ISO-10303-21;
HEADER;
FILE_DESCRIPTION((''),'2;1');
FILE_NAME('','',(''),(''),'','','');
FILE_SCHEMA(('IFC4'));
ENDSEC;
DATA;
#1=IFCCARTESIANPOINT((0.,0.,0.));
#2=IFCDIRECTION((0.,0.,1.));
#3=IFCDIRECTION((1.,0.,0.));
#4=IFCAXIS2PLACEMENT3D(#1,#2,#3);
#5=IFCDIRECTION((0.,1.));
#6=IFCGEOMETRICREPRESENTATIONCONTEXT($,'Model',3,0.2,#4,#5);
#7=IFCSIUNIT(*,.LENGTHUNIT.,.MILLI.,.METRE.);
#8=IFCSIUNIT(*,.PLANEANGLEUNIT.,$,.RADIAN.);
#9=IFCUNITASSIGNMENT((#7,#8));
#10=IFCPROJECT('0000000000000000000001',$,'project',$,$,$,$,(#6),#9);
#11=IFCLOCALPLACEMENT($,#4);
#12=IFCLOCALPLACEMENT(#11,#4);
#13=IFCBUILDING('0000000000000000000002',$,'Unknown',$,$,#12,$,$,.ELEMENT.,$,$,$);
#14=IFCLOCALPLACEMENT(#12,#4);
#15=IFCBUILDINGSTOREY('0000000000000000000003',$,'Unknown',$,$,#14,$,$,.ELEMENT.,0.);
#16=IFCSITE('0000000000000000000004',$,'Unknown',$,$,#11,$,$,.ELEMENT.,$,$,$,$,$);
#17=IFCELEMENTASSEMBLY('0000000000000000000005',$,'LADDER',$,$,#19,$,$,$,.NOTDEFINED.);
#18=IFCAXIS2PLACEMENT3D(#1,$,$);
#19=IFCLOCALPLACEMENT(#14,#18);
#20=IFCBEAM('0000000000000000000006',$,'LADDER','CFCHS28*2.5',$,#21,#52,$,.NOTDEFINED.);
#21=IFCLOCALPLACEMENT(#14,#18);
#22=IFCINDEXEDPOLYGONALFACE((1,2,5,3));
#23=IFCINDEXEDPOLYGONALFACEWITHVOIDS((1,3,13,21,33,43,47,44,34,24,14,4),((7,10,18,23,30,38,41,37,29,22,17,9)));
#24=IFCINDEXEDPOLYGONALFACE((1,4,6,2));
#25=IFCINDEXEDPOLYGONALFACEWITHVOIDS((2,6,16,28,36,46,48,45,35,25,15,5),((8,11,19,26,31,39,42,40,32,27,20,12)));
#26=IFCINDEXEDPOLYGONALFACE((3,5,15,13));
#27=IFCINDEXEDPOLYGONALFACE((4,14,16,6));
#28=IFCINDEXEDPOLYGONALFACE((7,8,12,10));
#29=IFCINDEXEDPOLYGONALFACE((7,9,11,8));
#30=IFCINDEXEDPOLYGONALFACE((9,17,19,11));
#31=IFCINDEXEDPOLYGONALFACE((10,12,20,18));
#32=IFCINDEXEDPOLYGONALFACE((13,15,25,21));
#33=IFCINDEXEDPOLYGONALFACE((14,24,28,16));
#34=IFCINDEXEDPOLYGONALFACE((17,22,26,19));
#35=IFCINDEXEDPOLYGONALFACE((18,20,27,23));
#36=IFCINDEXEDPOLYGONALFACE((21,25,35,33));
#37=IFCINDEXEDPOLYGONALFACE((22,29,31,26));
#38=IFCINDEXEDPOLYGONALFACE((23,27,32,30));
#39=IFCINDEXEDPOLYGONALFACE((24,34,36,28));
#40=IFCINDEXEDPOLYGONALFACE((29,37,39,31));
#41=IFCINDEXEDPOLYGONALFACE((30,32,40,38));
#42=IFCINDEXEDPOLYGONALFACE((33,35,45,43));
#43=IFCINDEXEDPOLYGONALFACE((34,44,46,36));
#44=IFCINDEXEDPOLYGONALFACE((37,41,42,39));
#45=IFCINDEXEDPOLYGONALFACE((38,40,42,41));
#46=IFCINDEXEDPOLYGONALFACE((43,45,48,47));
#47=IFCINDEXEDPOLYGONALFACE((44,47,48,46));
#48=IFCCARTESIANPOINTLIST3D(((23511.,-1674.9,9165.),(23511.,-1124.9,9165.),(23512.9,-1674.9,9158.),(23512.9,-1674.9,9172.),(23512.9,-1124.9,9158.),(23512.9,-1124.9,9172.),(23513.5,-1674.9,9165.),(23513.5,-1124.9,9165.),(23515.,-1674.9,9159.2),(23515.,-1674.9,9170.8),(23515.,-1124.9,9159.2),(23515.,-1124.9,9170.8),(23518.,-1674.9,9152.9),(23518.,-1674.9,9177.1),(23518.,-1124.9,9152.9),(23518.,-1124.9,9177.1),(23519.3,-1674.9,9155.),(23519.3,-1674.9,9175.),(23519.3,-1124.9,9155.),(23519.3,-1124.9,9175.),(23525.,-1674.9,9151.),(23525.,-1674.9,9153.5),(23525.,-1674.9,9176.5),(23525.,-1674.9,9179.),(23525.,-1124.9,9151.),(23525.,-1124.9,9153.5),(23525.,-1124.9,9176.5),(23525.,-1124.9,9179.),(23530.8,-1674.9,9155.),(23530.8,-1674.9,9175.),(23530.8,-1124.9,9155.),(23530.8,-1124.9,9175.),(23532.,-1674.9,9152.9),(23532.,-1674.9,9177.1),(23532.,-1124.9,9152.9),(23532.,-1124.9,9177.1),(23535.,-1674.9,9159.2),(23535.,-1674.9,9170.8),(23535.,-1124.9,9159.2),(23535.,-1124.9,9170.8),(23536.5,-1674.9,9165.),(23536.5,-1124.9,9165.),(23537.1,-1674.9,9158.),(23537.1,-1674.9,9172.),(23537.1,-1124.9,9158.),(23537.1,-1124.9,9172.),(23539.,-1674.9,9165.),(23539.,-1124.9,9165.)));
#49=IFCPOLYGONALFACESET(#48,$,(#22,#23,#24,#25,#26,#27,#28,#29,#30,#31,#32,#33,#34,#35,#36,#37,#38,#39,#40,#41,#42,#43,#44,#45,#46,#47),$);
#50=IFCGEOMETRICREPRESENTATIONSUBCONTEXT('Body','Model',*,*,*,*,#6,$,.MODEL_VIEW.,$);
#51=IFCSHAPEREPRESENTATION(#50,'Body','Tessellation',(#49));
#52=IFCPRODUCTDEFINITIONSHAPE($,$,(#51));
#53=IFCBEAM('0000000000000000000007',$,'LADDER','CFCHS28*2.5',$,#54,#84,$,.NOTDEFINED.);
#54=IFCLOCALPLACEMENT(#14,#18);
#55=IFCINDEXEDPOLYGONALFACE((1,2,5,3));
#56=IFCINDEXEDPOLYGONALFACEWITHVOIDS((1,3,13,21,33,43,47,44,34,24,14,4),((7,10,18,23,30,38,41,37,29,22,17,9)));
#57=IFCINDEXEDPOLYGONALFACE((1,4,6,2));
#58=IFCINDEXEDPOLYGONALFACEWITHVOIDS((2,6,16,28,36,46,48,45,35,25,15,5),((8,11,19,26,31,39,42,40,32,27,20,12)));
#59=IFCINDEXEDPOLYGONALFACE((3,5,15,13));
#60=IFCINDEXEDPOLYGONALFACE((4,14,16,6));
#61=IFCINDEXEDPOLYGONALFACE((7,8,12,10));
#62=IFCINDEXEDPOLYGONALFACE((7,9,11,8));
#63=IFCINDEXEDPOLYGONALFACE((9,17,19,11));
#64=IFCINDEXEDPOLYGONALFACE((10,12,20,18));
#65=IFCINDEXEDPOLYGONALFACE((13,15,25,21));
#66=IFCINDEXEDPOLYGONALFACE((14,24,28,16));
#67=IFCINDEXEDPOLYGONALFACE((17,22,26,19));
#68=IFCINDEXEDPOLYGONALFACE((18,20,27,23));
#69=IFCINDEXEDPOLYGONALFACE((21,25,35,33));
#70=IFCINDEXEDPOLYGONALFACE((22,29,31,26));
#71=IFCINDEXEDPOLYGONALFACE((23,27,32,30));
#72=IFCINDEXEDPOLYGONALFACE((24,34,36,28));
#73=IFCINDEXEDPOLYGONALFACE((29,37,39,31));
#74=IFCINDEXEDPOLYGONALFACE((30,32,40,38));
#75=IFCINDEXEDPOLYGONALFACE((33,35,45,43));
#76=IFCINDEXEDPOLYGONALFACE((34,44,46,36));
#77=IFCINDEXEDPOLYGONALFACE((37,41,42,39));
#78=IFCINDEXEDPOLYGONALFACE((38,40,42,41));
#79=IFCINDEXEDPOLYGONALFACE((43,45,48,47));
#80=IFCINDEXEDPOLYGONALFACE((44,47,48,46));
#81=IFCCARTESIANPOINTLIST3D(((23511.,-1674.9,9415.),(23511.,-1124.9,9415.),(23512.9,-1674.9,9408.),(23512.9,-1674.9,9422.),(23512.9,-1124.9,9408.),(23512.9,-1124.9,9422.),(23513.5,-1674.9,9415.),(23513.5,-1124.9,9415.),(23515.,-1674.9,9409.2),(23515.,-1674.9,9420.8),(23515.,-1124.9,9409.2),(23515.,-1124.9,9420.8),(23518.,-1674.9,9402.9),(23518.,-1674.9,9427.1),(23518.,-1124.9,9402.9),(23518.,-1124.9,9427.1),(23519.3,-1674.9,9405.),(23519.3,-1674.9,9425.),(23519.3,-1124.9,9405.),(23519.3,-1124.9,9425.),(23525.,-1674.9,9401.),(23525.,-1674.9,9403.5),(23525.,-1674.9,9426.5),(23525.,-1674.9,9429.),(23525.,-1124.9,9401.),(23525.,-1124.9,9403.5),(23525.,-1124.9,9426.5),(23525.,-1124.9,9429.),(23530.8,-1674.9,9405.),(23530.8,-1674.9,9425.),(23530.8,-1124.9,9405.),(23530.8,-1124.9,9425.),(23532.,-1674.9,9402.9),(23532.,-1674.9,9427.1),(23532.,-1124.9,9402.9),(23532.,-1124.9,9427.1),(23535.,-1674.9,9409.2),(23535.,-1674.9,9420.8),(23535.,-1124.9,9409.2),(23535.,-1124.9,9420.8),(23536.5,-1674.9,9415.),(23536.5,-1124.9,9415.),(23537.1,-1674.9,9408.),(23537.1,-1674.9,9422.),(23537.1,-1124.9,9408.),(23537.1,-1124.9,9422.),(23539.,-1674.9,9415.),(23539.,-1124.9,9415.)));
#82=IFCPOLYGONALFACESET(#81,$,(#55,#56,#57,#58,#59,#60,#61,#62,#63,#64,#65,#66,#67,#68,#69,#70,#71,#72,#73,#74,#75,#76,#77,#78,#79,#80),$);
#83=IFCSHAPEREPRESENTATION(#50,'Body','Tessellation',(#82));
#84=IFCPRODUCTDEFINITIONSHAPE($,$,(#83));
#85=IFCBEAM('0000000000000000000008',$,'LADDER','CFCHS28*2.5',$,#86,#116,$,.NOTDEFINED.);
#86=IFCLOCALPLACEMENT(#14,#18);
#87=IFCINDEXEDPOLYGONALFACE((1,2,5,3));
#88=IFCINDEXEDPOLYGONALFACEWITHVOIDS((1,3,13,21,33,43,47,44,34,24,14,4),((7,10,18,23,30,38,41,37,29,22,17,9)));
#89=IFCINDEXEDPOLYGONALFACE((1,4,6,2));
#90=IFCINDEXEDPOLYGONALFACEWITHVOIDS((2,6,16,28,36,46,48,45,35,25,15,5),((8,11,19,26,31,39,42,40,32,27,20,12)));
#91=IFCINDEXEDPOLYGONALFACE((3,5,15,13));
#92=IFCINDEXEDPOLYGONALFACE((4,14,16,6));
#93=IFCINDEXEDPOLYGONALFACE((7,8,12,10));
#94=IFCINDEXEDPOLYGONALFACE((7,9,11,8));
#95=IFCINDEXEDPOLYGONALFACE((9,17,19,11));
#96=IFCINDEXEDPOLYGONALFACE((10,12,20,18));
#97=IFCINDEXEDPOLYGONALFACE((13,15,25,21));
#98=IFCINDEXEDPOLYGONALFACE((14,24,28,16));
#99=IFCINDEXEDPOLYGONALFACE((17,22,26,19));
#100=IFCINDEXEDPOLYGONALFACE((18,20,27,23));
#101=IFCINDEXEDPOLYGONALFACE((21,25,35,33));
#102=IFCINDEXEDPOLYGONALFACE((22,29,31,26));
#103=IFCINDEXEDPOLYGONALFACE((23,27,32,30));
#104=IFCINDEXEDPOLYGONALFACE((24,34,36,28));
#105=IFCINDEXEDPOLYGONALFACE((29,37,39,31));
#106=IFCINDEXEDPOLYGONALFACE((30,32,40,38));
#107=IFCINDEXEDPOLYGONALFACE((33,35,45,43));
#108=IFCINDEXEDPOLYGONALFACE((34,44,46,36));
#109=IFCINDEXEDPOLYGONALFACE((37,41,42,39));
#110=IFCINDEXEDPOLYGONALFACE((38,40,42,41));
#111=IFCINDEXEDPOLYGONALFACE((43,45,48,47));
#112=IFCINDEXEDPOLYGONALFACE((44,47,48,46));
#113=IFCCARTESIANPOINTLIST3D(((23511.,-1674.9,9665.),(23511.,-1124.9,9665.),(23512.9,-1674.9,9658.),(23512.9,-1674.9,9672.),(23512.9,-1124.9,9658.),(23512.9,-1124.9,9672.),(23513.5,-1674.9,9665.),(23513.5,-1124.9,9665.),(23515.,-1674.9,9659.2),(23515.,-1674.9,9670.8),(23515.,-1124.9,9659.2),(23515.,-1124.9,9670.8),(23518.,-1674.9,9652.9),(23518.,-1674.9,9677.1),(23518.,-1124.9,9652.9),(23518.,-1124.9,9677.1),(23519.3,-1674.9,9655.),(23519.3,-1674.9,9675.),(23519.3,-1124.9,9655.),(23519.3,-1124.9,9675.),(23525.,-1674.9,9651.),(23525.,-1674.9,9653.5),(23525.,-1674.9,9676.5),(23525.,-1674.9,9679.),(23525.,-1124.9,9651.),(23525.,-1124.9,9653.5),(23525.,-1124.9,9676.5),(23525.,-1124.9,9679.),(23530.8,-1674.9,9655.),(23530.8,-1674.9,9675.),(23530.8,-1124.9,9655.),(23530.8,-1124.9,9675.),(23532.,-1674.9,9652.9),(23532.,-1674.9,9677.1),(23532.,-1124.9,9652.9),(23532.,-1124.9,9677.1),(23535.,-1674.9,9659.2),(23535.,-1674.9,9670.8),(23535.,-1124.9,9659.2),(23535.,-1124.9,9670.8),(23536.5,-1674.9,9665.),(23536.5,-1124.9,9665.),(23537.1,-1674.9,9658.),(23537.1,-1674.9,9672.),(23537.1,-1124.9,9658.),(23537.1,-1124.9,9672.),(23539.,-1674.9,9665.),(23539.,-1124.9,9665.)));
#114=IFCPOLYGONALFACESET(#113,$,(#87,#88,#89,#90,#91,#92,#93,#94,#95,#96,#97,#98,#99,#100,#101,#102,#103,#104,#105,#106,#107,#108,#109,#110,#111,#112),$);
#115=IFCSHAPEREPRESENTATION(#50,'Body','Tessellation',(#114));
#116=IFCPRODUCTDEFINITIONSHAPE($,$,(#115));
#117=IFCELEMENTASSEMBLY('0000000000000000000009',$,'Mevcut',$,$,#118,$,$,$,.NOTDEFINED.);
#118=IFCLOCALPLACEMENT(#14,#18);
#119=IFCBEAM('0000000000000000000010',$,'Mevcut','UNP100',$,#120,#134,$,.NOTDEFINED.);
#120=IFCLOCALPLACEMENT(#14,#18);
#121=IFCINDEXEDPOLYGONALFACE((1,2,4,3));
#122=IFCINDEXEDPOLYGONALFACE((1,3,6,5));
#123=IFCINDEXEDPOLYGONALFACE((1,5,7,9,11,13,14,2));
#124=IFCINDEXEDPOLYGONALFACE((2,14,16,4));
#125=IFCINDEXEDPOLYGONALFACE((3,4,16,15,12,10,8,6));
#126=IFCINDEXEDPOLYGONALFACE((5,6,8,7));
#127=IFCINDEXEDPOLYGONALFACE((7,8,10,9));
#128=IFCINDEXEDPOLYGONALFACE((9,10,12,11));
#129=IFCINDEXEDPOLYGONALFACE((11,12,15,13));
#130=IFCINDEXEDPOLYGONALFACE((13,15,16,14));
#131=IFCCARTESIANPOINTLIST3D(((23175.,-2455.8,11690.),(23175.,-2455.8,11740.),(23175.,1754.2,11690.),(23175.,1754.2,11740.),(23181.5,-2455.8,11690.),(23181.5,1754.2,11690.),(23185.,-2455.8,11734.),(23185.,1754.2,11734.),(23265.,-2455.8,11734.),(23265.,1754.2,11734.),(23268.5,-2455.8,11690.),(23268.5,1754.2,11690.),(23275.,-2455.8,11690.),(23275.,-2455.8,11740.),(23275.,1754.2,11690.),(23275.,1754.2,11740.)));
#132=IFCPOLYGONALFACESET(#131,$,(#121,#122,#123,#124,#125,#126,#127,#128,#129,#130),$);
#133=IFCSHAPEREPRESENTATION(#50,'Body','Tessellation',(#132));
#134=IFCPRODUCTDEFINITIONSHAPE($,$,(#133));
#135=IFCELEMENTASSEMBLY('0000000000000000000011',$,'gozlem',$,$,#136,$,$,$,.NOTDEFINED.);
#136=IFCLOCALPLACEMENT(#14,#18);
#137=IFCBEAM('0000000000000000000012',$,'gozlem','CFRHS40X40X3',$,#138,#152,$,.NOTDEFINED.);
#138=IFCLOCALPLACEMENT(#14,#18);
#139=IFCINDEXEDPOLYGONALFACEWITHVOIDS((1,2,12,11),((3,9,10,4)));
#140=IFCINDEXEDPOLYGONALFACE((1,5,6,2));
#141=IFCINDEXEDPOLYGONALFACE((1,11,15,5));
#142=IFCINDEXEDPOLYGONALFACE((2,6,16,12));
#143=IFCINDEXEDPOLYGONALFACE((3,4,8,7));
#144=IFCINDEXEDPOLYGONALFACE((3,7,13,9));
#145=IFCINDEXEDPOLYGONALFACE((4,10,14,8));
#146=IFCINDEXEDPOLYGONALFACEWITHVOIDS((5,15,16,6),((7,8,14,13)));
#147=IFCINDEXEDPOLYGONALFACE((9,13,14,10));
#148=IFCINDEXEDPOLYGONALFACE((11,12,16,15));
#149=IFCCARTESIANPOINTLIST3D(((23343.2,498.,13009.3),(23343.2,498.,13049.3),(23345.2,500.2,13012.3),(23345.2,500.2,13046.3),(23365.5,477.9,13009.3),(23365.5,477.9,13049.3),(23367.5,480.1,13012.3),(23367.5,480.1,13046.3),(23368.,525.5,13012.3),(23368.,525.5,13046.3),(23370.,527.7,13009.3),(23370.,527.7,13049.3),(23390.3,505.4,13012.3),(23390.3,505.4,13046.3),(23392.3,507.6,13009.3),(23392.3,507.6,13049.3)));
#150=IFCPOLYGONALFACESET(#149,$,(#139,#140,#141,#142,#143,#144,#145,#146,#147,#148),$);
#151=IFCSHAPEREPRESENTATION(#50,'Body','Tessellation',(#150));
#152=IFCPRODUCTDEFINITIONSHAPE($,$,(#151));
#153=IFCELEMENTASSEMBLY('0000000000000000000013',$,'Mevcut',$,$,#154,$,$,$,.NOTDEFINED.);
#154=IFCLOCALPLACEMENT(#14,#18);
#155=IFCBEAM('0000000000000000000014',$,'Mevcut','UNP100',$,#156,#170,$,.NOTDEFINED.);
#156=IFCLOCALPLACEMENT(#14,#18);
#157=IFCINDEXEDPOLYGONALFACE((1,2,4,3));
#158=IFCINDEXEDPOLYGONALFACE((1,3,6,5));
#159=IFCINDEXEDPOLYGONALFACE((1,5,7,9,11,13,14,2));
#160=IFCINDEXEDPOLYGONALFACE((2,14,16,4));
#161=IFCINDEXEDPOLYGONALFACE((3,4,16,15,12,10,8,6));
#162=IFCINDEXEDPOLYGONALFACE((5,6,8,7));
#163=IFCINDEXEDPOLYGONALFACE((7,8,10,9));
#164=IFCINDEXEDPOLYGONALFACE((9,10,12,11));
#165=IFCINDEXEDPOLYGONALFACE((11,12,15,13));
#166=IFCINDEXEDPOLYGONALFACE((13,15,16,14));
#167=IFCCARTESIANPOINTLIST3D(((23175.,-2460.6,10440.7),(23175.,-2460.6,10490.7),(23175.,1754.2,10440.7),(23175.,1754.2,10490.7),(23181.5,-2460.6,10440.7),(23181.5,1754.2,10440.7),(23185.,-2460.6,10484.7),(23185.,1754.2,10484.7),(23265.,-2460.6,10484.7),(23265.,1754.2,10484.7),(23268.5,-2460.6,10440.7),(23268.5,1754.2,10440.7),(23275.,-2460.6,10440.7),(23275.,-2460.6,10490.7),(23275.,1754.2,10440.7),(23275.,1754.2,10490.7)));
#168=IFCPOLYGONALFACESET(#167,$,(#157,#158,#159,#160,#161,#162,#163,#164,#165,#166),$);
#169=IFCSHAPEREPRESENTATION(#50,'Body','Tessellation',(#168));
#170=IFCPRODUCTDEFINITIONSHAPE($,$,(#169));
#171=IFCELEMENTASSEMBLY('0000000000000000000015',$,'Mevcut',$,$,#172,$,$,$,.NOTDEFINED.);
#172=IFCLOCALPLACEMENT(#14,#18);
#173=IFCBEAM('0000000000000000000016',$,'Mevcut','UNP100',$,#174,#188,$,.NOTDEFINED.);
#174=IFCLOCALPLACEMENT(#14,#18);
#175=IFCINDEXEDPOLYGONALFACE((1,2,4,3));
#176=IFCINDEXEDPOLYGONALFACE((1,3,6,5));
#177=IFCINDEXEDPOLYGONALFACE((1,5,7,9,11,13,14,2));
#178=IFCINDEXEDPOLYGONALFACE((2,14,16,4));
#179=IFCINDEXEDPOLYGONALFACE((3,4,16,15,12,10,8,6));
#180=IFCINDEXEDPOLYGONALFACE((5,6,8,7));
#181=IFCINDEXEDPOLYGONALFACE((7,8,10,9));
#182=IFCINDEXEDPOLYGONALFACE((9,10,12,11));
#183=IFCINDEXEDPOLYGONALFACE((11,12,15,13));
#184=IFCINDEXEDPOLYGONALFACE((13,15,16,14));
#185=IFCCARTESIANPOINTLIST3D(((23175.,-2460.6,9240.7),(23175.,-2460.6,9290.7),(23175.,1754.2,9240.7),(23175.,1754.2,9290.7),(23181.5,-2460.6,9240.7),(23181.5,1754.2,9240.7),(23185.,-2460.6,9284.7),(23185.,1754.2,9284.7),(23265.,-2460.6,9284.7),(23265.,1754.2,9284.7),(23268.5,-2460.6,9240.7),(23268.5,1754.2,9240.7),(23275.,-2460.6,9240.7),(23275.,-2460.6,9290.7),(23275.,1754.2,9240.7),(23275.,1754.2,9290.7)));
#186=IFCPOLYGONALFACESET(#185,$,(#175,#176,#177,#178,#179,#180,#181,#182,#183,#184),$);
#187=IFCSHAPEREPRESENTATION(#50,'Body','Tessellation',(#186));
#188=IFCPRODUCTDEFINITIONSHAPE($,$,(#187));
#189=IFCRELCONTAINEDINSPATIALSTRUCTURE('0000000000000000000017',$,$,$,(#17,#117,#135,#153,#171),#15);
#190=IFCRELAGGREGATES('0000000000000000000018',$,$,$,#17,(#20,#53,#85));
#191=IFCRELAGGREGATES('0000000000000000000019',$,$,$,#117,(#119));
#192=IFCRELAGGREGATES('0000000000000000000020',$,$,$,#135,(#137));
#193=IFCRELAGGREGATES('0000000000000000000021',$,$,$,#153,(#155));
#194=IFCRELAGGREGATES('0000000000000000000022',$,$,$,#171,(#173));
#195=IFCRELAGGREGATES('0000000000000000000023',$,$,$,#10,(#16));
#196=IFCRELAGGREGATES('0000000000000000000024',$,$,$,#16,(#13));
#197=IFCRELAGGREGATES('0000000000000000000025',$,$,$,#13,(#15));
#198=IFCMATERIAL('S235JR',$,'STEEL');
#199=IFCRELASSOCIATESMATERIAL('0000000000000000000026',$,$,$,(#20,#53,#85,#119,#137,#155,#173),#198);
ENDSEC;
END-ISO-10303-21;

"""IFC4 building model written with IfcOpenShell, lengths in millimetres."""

from ifc_helpers import new_model, si_unit, direction, frame, origin_with_axes, place, context, subcontext, project, spatial, line, indexed_curve, outline, extrude, material, element, aggregate, save


model = new_model("IFC4")

# Units and contexts
model_context = context("Model", 3, precision=0.2, world=origin_with_axes(), true_north=direction((0.0, 1.0)))
body_context = subcontext(model_context, "Body", "Model", "MODEL_VIEW")
ifc_project = project(units=[si_unit("LENGTHUNIT", "METRE", prefix="MILLI"), si_unit("PLANEANGLEUNIT", "RADIAN")], contexts=[model_context])

# Site, building, storey
site_placement = place(None, origin_with_axes())
site = spatial("IfcSite", under=ifc_project, at=site_placement, Name="Unknown", CompositionType="ELEMENT")
building_placement = place(site_placement, origin_with_axes())
building = spatial("IfcBuilding", under=site, at=building_placement, Name="Unknown", CompositionType="ELEMENT")
storey_placement = place(building_placement, origin_with_axes())
storey = spatial("IfcBuildingStorey", under=building, at=storey_placement, Name="Unknown", CompositionType="ELEMENT", Elevation=0.0)

# Element assembly, beams
assembly_1_placement = place(storey_placement, frame((23525.0, -1699.9, 5175.0), z_axis=(0.0, 1.0, 0.0), x_axis=(0.0, 0.0, 1.0)))
assembly_1 = element("IfcElementAssembly", 1, at=assembly_1_placement, inside=storey, Name="LADDER", PredefinedType="NOTDEFINED")
ifc_material = material(Name="S235JR", Category="STEEL")
beam_1_placement = place(assembly_1_placement, frame((3990.0, 0.0, 25.0), z_axis=(0.0, -1.0, 0.0), x_axis=(0.0, 0.0, 1.0)))
beam_1 = element("IfcBeam", 2, at=beam_1_placement, material=ifc_material, Name="LADDER", Description="CFCHS28*2.5", PredefinedType="NOTDEFINED", context=body_context, shape_type="SolidModel", body=[
    extrude(outline(indexed_curve([(14.0, 0.0), (12.1, 7.0), (7.0, 12.1), (0.0, 14.0), (-7.0, 12.1), (-12.1, 7.0), (-14.0, 0.0), (-12.1, -7.0), (-7.0, -12.1), (0.0, -14.0), (7.0, -12.1), (12.1, -7.0)], segments=[line(1, 2, 3, 4, 5, 6, 7, 8, 9, 10, 11, 12, 1)]), holes=[indexed_curve([(11.5, 0.0), (10.0, -5.8), (5.8, -10.0), (0.0, -11.5), (-5.8, -10.0), (-10.0, -5.8), (-11.5, 0.0), (-10.0, 5.8), (-5.8, 10.0), (0.0, 11.5), (5.8, 10.0), (10.0, 5.8)], segments=[line(1, 2, 3, 4, 5, 6, 7, 8, 9, 10, 11, 12, 1)])]), frame((0.0, 0.0, 0.0), z_axis=(-1.0, 0.0, 0.0), x_axis=(0.0, 0.0, 1.0)), (0.0, 0.0, -1.0), 550.0),
])
beam_2_placement = place(assembly_1_placement, frame((4240.0, 0.0, 25.0), z_axis=(0.0, -1.0, 0.0), x_axis=(0.0, 0.0, 1.0)))
beam_2 = element("IfcBeam", 3, at=beam_2_placement, material=ifc_material, Name="LADDER", Description="CFCHS28*2.5", PredefinedType="NOTDEFINED", context=body_context, shape_type="SolidModel", body=[
    extrude(outline(indexed_curve([(14.0, 0.0), (12.1, 7.0), (7.0, 12.1), (0.0, 14.0), (-7.0, 12.1), (-12.1, 7.0), (-14.0, 0.0), (-12.1, -7.0), (-7.0, -12.1), (0.0, -14.0), (7.0, -12.1), (12.1, -7.0)], segments=[line(1, 2, 3, 4, 5, 6, 7, 8, 9, 10, 11, 12, 1)]), holes=[indexed_curve([(11.5, 0.0), (10.0, -5.8), (5.8, -10.0), (0.0, -11.5), (-5.8, -10.0), (-10.0, -5.8), (-11.5, 0.0), (-10.0, 5.8), (-5.8, 10.0), (0.0, 11.5), (5.8, 10.0), (10.0, 5.8)], segments=[line(1, 2, 3, 4, 5, 6, 7, 8, 9, 10, 11, 12, 1)])]), frame((0.0, 0.0, 0.0), z_axis=(-1.0, 0.0, 0.0), x_axis=(0.0, 0.0, 1.0)), (0.0, 0.0, -1.0), 550.0),
])
beam_3_placement = place(assembly_1_placement, frame((4490.0, 0.0, 25.0), z_axis=(0.0, -1.0, 0.0), x_axis=(0.0, 0.0, 1.0)))
beam_3 = element("IfcBeam", 4, at=beam_3_placement, material=ifc_material, Name="LADDER", Description="CFCHS28*2.5", PredefinedType="NOTDEFINED", context=body_context, shape_type="SolidModel", body=[
    extrude(outline(indexed_curve([(14.0, 0.0), (12.1, 7.0), (7.0, 12.1), (0.0, 14.0), (-7.0, 12.1), (-12.1, 7.0), (-14.0, 0.0), (-12.1, -7.0), (-7.0, -12.1), (0.0, -14.0), (7.0, -12.1), (12.1, -7.0)], segments=[line(1, 2, 3, 4, 5, 6, 7, 8, 9, 10, 11, 12, 1)]), holes=[indexed_curve([(11.5, 0.0), (10.0, -5.8), (5.8, -10.0), (0.0, -11.5), (-5.8, -10.0), (-10.0, -5.8), (-11.5, 0.0), (-10.0, 5.8), (-5.8, 10.0), (0.0, 11.5), (5.8, 10.0), (10.0, 5.8)], segments=[line(1, 2, 3, 4, 5, 6, 7, 8, 9, 10, 11, 12, 1)])]), frame((0.0, 0.0, 0.0), z_axis=(-1.0, 0.0, 0.0), x_axis=(0.0, 0.0, 1.0)), (0.0, 0.0, -1.0), 550.0),
])
aggregate(assembly_1, [beam_1, beam_2, beam_3])

# Element assemblies, beams
assembly_2_placement = place(storey_placement, frame((23225.0, 1754.2, 11715.0), z_axis=(0.0, 0.0, -1.0), x_axis=(0.0, -1.0, 0.0)))
assembly_2 = element("IfcElementAssembly", 5, at=assembly_2_placement, inside=storey, Name="Mevcut", PredefinedType="NOTDEFINED")
beam_4_placement = place(assembly_2_placement, origin_with_axes())
beam_4 = element("IfcBeam", 6, at=beam_4_placement, material=ifc_material, Name="Mevcut", Description="UNP100", PredefinedType="NOTDEFINED", context=body_context, shape_type="SolidModel", body=[
    extrude(outline(indexed_curve([(-25.0, -50.0), (25.0, -50.0), (25.0, -43.5), (-19.0, -40.0), (-19.0, 40.0), (25.0, 43.5), (25.0, 50.0), (-25.0, 50.0)], segments=[line(1, 2, 3, 4, 5, 6, 7, 8, 1)])), frame((0.0, 0.0, 0.0), z_axis=(-1.0, 0.0, 0.0), x_axis=(0.0, 0.0, 1.0)), (0.0, 0.0, -1.0), 4210.0),
])
aggregate(assembly_2, [beam_4])
assembly_3_placement = place(storey_placement, frame((23356.6, 512.8, 13029.3), z_axis=(0.0, 0.0, -1.0), x_axis=(0.743145, -0.669131, 0.0)))
assembly_3 = element("IfcElementAssembly", 7, at=assembly_3_placement, inside=storey, Name="gozlem", PredefinedType="NOTDEFINED")
beam_5_placement = place(assembly_3_placement, origin_with_axes())
beam_5 = element("IfcBeam", 8, at=beam_5_placement, material=ifc_material, Name="gozlem", Description="CFRHS40X40X3", PredefinedType="NOTDEFINED", context=body_context, shape_type="SolidModel", body=[
    extrude(outline(indexed_curve([(-20.0, -20.0), (20.0, -20.0), (20.0, 20.0), (-20.0, 20.0)], segments=[line(1, 2, 3, 4, 1)]), holes=[indexed_curve([(-17.0, -17.0), (-17.0, 17.0), (17.0, 17.0), (17.0, -17.0)], segments=[line(1, 2, 3, 4, 1)])]), frame((0.0, 0.0, 0.0), z_axis=(-1.0, 0.0, 0.0), x_axis=(0.0, 0.0, 1.0)), (0.0, 0.0, -1.0), 30.0),
])
aggregate(assembly_3, [beam_5])
assembly_4_placement = place(storey_placement, frame((23225.0, 1754.2, 10465.7), z_axis=(0.0, 0.0, -1.0), x_axis=(0.0, -1.0, 0.0)))
assembly_4 = element("IfcElementAssembly", 9, at=assembly_4_placement, inside=storey, Name="Mevcut", PredefinedType="NOTDEFINED")
beam_6_placement = place(assembly_4_placement, origin_with_axes())
beam_6 = element("IfcBeam", 10, at=beam_6_placement, material=ifc_material, Name="Mevcut", Description="UNP100", PredefinedType="NOTDEFINED", context=body_context, shape_type="SolidModel", body=[
    extrude(outline(indexed_curve([(-25.0, -50.0), (25.0, -50.0), (25.0, -43.5), (-19.0, -40.0), (-19.0, 40.0), (25.0, 43.5), (25.0, 50.0), (-25.0, 50.0)], segments=[line(1, 2, 3, 4, 5, 6, 7, 8, 1)])), frame((0.0, 0.0, 0.0), z_axis=(-1.0, 0.0, 0.0), x_axis=(0.0, 0.0, 1.0)), (0.0, 0.0, -1.0), 4214.9),
])
aggregate(assembly_4, [beam_6])
assembly_5_placement = place(storey_placement, frame((23225.0, 1754.2, 9265.7), z_axis=(0.0, 0.0, -1.0), x_axis=(0.0, -1.0, 0.0)))
assembly_5 = element("IfcElementAssembly", 11, at=assembly_5_placement, inside=storey, Name="Mevcut", PredefinedType="NOTDEFINED")
beam_7_placement = place(assembly_5_placement, origin_with_axes())
beam_7 = element("IfcBeam", 12, at=beam_7_placement, material=ifc_material, Name="Mevcut", Description="UNP100", PredefinedType="NOTDEFINED", context=body_context, shape_type="SolidModel", body=[
    extrude(outline(indexed_curve([(-25.0, -50.0), (25.0, -50.0), (25.0, -43.5), (-19.0, -40.0), (-19.0, 40.0), (25.0, 43.5), (25.0, 50.0), (-25.0, 50.0)], segments=[line(1, 2, 3, 4, 5, 6, 7, 8, 1)])), frame((0.0, 0.0, 0.0), z_axis=(-1.0, 0.0, 0.0), x_axis=(0.0, 0.0, 1.0)), (0.0, 0.0, -1.0), 4214.9),
])
aggregate(assembly_5, [beam_7])

save(model, "model.ifc")
